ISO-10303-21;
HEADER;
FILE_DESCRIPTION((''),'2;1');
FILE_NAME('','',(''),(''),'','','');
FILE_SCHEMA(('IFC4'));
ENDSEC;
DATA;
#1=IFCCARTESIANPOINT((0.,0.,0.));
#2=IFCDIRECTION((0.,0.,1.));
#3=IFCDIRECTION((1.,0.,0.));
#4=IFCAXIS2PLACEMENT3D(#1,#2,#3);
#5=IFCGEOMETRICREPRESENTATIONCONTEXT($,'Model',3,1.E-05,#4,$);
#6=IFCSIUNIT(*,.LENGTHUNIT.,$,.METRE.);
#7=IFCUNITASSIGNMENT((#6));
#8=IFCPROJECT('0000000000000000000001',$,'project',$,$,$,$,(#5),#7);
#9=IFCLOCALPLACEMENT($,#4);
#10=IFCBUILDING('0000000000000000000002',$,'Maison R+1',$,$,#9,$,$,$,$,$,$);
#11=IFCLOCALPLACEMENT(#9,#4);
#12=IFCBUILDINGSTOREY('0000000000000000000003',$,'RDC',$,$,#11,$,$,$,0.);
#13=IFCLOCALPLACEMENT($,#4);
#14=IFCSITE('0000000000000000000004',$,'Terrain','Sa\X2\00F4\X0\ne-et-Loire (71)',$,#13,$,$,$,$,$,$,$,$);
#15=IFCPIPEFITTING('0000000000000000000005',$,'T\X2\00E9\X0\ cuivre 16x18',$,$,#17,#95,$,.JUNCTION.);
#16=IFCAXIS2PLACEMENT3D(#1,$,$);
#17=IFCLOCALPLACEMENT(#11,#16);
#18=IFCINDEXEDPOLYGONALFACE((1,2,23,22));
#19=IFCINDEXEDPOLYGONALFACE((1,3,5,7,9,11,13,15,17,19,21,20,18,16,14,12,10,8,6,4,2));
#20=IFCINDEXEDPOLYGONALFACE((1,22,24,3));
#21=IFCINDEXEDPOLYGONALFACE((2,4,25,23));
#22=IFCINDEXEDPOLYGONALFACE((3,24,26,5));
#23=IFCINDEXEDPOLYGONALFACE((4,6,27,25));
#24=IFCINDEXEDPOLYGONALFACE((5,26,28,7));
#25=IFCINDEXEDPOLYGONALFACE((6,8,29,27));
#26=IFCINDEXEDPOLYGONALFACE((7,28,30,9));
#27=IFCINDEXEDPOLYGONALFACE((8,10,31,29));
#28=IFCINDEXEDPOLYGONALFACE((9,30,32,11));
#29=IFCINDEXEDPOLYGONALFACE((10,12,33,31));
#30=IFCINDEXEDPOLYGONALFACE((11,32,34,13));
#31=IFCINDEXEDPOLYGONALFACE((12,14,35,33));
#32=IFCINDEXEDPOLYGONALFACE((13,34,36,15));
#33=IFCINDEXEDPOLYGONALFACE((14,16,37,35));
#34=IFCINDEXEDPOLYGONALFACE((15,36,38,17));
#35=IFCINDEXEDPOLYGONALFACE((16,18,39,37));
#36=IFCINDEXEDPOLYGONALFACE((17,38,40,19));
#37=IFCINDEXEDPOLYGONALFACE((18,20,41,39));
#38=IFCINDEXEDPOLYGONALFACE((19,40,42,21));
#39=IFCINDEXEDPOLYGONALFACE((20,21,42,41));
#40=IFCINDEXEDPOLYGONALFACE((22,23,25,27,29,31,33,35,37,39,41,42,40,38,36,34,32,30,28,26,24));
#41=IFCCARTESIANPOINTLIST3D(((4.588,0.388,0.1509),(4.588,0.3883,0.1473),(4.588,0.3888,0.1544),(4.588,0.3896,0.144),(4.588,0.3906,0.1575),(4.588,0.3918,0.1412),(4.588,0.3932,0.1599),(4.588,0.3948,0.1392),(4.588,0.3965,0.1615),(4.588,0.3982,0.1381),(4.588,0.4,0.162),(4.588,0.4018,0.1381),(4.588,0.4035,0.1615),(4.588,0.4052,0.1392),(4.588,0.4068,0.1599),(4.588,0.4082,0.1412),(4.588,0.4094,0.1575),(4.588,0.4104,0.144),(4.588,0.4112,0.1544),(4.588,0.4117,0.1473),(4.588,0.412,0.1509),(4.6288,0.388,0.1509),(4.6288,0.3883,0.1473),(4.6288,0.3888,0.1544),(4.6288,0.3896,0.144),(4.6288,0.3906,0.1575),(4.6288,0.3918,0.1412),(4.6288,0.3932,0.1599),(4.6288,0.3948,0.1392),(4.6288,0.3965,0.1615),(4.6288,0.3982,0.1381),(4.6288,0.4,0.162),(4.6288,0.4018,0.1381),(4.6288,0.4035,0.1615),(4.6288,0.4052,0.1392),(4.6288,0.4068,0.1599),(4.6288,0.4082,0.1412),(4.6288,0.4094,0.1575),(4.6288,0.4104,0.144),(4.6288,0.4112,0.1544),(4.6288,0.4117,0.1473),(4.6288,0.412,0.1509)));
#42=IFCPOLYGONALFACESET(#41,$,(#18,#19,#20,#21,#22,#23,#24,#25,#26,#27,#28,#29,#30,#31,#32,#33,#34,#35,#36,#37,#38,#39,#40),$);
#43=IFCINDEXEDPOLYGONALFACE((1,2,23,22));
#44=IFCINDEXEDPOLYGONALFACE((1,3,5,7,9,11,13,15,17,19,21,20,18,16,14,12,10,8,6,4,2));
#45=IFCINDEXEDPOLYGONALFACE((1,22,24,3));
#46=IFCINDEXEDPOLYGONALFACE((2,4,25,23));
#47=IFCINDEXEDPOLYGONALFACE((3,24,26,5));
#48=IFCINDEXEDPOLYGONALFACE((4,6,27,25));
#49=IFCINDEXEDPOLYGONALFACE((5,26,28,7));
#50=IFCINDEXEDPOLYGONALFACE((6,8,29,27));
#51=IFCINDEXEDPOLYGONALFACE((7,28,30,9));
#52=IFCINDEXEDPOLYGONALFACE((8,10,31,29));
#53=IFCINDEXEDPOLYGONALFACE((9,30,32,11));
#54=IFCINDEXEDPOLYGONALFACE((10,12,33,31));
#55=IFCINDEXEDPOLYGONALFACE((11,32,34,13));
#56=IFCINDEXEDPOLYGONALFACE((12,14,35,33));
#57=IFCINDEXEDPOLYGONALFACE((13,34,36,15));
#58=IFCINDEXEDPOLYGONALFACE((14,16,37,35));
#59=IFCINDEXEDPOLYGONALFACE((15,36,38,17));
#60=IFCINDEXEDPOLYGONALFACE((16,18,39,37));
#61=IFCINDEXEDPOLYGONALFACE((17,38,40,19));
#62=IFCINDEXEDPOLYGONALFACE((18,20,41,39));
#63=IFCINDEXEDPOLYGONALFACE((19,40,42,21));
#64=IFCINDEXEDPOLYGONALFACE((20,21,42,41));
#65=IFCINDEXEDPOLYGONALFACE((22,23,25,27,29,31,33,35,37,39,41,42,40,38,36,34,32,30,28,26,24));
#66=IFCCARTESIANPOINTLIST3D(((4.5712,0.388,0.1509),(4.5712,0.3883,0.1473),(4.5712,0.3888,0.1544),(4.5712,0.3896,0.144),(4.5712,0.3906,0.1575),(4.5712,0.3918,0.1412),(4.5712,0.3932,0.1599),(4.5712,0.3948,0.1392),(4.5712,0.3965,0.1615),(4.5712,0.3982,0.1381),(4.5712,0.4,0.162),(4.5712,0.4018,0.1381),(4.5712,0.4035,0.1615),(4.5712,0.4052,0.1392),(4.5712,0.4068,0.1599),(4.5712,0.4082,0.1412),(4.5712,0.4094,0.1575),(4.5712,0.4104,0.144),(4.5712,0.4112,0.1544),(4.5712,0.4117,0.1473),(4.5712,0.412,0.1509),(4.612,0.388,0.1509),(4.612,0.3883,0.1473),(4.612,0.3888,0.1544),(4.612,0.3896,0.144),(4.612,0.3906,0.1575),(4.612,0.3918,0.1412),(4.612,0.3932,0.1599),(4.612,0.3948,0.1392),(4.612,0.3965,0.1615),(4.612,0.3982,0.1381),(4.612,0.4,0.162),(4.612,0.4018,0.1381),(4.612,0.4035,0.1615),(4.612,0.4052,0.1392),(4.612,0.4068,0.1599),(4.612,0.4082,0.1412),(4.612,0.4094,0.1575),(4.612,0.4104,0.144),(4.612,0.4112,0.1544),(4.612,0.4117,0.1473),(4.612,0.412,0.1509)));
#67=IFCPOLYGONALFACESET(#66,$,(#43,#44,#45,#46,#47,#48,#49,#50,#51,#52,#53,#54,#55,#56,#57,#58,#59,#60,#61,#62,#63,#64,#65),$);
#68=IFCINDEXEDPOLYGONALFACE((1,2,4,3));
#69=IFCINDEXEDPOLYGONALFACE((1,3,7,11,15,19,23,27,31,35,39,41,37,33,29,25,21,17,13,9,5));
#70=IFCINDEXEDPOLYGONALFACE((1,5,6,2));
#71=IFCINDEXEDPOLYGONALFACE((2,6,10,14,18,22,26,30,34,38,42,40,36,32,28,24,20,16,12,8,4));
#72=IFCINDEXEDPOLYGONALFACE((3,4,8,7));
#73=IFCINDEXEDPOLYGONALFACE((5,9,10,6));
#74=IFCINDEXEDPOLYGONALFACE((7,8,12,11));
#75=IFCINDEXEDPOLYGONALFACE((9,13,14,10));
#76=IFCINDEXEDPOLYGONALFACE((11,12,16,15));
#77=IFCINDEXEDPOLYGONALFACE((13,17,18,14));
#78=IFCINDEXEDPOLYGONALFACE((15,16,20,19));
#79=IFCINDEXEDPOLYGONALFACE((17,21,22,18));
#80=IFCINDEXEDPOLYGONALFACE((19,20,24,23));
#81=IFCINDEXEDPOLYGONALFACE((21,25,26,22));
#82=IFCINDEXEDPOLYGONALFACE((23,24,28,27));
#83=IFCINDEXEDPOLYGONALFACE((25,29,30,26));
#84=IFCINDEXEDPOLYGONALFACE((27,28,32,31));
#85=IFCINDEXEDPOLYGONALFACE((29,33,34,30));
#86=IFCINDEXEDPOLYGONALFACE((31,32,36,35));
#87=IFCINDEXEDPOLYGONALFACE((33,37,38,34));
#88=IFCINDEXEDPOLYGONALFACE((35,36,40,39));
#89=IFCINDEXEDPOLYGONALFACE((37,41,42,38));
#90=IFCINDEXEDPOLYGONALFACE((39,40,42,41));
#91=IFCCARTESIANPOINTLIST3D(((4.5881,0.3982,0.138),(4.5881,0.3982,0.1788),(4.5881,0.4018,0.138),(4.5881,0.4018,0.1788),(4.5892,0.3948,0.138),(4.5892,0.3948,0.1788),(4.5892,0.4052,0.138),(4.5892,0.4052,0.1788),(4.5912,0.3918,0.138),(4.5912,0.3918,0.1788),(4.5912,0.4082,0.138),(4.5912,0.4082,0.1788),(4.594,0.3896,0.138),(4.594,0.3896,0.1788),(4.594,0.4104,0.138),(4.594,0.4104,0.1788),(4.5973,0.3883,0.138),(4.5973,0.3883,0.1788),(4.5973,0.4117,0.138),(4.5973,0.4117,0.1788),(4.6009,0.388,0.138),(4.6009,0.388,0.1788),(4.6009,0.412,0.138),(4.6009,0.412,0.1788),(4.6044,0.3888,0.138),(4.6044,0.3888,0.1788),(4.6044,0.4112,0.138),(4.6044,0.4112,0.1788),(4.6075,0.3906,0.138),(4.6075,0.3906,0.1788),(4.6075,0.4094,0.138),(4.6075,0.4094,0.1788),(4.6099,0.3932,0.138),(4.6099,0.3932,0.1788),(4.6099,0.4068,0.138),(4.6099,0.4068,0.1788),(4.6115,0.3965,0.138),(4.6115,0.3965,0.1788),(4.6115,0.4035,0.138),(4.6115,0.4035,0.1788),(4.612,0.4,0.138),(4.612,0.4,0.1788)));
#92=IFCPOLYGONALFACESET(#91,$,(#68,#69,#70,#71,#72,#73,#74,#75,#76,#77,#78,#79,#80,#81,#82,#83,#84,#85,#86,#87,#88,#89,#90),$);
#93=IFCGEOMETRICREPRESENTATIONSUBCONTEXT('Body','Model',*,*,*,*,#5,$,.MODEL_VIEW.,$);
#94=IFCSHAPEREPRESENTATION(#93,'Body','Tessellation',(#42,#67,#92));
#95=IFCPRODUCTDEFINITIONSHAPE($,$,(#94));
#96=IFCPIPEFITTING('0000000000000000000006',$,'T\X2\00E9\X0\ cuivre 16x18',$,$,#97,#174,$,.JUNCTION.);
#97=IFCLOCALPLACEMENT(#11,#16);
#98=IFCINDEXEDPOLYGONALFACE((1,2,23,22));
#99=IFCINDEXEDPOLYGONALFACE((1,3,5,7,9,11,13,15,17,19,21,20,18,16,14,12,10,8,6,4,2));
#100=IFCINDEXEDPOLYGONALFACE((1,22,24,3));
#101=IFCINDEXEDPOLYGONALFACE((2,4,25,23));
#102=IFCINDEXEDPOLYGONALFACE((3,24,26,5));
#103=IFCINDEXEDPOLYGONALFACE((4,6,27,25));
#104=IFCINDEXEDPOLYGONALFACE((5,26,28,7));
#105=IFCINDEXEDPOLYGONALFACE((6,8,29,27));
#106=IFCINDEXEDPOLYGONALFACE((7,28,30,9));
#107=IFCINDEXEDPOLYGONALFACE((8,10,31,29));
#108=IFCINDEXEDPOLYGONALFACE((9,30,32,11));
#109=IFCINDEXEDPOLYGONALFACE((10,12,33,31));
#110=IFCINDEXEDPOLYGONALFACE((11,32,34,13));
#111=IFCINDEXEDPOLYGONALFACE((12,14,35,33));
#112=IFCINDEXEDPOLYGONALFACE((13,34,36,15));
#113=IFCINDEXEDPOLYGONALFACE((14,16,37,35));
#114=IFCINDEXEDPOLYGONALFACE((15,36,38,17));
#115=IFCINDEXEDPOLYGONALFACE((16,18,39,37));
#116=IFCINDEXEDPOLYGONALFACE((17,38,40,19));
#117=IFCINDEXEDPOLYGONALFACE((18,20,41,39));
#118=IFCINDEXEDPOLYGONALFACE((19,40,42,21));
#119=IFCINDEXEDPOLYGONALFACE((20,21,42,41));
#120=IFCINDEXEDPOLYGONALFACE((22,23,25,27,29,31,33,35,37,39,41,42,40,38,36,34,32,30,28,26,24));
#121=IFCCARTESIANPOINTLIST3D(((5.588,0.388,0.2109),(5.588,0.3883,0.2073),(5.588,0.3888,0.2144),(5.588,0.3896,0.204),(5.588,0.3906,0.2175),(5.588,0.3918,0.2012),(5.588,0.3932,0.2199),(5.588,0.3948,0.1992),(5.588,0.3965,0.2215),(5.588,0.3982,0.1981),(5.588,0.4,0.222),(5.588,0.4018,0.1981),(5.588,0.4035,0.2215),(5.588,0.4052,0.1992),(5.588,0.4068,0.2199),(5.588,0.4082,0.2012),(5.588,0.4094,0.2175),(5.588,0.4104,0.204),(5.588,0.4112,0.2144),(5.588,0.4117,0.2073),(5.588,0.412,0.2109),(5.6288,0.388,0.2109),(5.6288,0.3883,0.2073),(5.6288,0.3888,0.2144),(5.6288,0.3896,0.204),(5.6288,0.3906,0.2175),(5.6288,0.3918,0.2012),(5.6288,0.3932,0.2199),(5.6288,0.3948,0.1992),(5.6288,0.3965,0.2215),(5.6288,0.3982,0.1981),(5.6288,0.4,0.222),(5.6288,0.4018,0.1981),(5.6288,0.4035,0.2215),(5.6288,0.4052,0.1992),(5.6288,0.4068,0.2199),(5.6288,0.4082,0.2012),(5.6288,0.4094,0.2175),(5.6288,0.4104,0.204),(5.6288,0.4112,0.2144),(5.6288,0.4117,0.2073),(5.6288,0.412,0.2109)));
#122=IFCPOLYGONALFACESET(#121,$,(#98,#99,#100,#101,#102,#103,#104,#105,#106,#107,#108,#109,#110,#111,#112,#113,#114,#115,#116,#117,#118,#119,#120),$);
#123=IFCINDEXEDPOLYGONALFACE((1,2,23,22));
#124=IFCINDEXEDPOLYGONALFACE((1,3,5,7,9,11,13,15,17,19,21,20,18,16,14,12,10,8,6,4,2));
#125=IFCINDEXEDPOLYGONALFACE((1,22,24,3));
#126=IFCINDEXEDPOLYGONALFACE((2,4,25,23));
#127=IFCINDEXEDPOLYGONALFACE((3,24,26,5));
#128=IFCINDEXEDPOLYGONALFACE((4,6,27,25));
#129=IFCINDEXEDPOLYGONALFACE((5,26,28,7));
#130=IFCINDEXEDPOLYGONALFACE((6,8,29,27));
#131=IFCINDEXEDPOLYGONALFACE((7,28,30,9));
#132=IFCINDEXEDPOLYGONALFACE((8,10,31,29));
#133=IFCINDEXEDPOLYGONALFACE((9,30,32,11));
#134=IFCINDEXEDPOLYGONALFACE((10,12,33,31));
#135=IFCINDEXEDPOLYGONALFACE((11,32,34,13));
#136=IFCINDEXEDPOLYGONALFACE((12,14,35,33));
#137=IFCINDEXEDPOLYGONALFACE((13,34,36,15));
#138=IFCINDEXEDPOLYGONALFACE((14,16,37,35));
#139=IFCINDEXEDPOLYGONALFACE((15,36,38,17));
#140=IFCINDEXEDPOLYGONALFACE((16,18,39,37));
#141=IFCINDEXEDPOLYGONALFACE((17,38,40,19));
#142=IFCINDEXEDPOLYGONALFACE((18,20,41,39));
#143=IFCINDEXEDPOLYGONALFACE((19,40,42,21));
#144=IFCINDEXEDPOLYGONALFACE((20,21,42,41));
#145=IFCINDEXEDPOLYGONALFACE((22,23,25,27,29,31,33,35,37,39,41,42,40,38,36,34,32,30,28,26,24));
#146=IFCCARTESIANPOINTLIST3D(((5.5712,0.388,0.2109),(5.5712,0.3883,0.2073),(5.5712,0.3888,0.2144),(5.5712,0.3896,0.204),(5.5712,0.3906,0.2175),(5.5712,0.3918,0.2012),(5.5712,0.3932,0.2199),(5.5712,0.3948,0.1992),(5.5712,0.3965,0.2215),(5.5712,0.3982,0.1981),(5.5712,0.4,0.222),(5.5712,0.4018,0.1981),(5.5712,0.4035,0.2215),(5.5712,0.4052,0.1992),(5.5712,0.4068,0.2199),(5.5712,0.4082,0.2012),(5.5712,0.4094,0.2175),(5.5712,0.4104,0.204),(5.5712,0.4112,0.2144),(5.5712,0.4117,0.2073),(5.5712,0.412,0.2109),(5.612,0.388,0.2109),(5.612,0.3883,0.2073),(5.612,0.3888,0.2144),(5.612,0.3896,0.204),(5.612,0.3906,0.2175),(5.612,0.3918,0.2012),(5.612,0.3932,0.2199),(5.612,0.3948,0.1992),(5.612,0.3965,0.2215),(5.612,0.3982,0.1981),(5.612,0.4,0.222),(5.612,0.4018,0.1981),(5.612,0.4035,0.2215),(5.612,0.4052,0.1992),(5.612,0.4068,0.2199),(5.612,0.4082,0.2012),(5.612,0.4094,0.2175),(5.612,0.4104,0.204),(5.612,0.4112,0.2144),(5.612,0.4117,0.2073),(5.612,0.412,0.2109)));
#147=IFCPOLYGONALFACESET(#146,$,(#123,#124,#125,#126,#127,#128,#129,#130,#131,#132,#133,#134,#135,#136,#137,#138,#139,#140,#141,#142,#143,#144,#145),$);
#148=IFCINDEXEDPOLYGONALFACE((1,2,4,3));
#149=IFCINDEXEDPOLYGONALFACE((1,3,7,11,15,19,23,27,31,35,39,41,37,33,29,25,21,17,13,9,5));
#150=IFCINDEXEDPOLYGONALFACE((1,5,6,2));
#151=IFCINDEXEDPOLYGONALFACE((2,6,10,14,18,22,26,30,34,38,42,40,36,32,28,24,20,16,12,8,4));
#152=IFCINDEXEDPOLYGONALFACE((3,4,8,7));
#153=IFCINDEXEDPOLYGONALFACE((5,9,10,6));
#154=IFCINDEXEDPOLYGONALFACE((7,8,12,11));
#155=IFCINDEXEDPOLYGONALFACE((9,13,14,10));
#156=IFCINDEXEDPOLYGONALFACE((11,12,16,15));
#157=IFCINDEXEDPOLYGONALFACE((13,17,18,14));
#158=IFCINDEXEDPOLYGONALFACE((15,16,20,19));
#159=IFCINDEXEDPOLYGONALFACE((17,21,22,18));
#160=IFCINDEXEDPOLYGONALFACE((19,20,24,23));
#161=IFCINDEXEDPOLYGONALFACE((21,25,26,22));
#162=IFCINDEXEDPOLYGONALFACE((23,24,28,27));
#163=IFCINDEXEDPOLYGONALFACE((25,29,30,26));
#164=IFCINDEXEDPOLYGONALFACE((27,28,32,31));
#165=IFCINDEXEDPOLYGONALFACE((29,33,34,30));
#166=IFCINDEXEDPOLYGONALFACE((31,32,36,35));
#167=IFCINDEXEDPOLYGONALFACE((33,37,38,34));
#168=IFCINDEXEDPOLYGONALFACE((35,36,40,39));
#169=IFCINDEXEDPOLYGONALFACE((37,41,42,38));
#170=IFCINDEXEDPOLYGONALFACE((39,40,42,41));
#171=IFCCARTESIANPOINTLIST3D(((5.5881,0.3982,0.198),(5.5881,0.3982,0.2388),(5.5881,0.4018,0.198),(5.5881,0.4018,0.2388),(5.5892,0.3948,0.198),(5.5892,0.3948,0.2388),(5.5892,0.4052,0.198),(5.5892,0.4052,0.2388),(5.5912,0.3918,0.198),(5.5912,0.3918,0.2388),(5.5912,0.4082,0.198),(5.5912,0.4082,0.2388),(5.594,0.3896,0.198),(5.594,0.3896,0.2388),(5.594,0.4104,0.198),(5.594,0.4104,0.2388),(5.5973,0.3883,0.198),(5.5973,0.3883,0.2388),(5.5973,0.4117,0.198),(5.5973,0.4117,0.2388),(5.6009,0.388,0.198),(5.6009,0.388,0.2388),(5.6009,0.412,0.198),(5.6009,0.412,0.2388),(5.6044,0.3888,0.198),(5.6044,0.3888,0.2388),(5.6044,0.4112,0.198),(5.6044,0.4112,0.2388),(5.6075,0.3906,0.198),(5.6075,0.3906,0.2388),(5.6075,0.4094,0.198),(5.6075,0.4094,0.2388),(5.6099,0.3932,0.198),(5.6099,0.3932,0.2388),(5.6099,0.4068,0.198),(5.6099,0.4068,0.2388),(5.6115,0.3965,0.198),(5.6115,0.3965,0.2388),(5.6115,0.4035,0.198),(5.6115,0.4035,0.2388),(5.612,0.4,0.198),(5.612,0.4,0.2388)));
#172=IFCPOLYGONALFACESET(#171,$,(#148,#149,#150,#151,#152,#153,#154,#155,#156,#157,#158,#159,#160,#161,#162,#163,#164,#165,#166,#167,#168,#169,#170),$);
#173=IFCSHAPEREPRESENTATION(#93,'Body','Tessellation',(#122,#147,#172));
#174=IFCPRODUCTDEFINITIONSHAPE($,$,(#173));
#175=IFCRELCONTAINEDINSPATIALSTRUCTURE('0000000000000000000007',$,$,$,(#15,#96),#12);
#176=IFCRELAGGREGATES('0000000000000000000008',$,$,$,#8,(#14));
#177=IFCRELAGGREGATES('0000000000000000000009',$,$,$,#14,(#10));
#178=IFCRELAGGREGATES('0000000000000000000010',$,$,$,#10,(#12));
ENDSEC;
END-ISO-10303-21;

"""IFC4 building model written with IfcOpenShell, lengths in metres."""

from ifc_helpers import new_model, si_unit, frame, origin_with_axes, place, context, subcontext, project, spatial, circle, extrude, element, save


model = new_model("IFC4")

# Units and contexts
model_context = context("Model", 3, precision=1e-05, world=origin_with_axes())
body_context = subcontext(model_context, "Body", "Model", "MODEL_VIEW")
ifc_project = project(units=[si_unit("LENGTHUNIT", "METRE")], contexts=[model_context])

# Site, building, storey
site_placement = place(None, origin_with_axes())
site = spatial("IfcSite", under=ifc_project, at=site_placement, Name="Terrain", Description="Saône-et-Loire (71)")
building_placement = place(None, origin_with_axes())
building = spatial("IfcBuilding", under=site, at=building_placement, Name="Maison R+1")
storey_placement = place(building_placement, origin_with_axes())
storey = spatial("IfcBuildingStorey", under=building, at=storey_placement, Name="RDC", Elevation=0.0)

# Pipe fittings
for number, where, z_axis, x_axis, name in (
    (1, (4.6, 0.4, 0.15), (0.0, 0.0, 1.0), (1.0, 0.0, 0.0), "Té cuivre 16x18"),
    (2, (5.6, 0.4, 0.21), (0.0, 0.0, 1.0), (1.0, 0.0, 0.0), "Té cuivre 16x18"),
):
    element("IfcPipeFitting", number, at=place(storey_placement, frame(where, z_axis=z_axis, x_axis=x_axis)), inside=storey, Name=name, PredefinedType="JUNCTION", context=body_context, shape_type="SweptSolid", body=[
        extrude(circle(Radius=0.012), frame((-0.012, 0.0, 0.0), z_axis=(1.0, 0.0, 0.0), x_axis=(0.0, 0.0, 1.0)), (0.0, 0.0, 1.0), 0.0408),
        extrude(circle(Radius=0.012), frame((0.012, 0.0, 0.0), z_axis=(-1.0, 0.0, 0.0), x_axis=(0.0, 0.0, 1.0)), (0.0, 0.0, 1.0), 0.0408),
        extrude(circle(Radius=0.012), frame((0.0, 0.0, -0.012), z_axis=(0.0, 0.0, 1.0), x_axis=(1.0, 0.0, 0.0)), (0.0, 0.0, 1.0), 0.0408),
    ])

save(model, "model.ifc")
